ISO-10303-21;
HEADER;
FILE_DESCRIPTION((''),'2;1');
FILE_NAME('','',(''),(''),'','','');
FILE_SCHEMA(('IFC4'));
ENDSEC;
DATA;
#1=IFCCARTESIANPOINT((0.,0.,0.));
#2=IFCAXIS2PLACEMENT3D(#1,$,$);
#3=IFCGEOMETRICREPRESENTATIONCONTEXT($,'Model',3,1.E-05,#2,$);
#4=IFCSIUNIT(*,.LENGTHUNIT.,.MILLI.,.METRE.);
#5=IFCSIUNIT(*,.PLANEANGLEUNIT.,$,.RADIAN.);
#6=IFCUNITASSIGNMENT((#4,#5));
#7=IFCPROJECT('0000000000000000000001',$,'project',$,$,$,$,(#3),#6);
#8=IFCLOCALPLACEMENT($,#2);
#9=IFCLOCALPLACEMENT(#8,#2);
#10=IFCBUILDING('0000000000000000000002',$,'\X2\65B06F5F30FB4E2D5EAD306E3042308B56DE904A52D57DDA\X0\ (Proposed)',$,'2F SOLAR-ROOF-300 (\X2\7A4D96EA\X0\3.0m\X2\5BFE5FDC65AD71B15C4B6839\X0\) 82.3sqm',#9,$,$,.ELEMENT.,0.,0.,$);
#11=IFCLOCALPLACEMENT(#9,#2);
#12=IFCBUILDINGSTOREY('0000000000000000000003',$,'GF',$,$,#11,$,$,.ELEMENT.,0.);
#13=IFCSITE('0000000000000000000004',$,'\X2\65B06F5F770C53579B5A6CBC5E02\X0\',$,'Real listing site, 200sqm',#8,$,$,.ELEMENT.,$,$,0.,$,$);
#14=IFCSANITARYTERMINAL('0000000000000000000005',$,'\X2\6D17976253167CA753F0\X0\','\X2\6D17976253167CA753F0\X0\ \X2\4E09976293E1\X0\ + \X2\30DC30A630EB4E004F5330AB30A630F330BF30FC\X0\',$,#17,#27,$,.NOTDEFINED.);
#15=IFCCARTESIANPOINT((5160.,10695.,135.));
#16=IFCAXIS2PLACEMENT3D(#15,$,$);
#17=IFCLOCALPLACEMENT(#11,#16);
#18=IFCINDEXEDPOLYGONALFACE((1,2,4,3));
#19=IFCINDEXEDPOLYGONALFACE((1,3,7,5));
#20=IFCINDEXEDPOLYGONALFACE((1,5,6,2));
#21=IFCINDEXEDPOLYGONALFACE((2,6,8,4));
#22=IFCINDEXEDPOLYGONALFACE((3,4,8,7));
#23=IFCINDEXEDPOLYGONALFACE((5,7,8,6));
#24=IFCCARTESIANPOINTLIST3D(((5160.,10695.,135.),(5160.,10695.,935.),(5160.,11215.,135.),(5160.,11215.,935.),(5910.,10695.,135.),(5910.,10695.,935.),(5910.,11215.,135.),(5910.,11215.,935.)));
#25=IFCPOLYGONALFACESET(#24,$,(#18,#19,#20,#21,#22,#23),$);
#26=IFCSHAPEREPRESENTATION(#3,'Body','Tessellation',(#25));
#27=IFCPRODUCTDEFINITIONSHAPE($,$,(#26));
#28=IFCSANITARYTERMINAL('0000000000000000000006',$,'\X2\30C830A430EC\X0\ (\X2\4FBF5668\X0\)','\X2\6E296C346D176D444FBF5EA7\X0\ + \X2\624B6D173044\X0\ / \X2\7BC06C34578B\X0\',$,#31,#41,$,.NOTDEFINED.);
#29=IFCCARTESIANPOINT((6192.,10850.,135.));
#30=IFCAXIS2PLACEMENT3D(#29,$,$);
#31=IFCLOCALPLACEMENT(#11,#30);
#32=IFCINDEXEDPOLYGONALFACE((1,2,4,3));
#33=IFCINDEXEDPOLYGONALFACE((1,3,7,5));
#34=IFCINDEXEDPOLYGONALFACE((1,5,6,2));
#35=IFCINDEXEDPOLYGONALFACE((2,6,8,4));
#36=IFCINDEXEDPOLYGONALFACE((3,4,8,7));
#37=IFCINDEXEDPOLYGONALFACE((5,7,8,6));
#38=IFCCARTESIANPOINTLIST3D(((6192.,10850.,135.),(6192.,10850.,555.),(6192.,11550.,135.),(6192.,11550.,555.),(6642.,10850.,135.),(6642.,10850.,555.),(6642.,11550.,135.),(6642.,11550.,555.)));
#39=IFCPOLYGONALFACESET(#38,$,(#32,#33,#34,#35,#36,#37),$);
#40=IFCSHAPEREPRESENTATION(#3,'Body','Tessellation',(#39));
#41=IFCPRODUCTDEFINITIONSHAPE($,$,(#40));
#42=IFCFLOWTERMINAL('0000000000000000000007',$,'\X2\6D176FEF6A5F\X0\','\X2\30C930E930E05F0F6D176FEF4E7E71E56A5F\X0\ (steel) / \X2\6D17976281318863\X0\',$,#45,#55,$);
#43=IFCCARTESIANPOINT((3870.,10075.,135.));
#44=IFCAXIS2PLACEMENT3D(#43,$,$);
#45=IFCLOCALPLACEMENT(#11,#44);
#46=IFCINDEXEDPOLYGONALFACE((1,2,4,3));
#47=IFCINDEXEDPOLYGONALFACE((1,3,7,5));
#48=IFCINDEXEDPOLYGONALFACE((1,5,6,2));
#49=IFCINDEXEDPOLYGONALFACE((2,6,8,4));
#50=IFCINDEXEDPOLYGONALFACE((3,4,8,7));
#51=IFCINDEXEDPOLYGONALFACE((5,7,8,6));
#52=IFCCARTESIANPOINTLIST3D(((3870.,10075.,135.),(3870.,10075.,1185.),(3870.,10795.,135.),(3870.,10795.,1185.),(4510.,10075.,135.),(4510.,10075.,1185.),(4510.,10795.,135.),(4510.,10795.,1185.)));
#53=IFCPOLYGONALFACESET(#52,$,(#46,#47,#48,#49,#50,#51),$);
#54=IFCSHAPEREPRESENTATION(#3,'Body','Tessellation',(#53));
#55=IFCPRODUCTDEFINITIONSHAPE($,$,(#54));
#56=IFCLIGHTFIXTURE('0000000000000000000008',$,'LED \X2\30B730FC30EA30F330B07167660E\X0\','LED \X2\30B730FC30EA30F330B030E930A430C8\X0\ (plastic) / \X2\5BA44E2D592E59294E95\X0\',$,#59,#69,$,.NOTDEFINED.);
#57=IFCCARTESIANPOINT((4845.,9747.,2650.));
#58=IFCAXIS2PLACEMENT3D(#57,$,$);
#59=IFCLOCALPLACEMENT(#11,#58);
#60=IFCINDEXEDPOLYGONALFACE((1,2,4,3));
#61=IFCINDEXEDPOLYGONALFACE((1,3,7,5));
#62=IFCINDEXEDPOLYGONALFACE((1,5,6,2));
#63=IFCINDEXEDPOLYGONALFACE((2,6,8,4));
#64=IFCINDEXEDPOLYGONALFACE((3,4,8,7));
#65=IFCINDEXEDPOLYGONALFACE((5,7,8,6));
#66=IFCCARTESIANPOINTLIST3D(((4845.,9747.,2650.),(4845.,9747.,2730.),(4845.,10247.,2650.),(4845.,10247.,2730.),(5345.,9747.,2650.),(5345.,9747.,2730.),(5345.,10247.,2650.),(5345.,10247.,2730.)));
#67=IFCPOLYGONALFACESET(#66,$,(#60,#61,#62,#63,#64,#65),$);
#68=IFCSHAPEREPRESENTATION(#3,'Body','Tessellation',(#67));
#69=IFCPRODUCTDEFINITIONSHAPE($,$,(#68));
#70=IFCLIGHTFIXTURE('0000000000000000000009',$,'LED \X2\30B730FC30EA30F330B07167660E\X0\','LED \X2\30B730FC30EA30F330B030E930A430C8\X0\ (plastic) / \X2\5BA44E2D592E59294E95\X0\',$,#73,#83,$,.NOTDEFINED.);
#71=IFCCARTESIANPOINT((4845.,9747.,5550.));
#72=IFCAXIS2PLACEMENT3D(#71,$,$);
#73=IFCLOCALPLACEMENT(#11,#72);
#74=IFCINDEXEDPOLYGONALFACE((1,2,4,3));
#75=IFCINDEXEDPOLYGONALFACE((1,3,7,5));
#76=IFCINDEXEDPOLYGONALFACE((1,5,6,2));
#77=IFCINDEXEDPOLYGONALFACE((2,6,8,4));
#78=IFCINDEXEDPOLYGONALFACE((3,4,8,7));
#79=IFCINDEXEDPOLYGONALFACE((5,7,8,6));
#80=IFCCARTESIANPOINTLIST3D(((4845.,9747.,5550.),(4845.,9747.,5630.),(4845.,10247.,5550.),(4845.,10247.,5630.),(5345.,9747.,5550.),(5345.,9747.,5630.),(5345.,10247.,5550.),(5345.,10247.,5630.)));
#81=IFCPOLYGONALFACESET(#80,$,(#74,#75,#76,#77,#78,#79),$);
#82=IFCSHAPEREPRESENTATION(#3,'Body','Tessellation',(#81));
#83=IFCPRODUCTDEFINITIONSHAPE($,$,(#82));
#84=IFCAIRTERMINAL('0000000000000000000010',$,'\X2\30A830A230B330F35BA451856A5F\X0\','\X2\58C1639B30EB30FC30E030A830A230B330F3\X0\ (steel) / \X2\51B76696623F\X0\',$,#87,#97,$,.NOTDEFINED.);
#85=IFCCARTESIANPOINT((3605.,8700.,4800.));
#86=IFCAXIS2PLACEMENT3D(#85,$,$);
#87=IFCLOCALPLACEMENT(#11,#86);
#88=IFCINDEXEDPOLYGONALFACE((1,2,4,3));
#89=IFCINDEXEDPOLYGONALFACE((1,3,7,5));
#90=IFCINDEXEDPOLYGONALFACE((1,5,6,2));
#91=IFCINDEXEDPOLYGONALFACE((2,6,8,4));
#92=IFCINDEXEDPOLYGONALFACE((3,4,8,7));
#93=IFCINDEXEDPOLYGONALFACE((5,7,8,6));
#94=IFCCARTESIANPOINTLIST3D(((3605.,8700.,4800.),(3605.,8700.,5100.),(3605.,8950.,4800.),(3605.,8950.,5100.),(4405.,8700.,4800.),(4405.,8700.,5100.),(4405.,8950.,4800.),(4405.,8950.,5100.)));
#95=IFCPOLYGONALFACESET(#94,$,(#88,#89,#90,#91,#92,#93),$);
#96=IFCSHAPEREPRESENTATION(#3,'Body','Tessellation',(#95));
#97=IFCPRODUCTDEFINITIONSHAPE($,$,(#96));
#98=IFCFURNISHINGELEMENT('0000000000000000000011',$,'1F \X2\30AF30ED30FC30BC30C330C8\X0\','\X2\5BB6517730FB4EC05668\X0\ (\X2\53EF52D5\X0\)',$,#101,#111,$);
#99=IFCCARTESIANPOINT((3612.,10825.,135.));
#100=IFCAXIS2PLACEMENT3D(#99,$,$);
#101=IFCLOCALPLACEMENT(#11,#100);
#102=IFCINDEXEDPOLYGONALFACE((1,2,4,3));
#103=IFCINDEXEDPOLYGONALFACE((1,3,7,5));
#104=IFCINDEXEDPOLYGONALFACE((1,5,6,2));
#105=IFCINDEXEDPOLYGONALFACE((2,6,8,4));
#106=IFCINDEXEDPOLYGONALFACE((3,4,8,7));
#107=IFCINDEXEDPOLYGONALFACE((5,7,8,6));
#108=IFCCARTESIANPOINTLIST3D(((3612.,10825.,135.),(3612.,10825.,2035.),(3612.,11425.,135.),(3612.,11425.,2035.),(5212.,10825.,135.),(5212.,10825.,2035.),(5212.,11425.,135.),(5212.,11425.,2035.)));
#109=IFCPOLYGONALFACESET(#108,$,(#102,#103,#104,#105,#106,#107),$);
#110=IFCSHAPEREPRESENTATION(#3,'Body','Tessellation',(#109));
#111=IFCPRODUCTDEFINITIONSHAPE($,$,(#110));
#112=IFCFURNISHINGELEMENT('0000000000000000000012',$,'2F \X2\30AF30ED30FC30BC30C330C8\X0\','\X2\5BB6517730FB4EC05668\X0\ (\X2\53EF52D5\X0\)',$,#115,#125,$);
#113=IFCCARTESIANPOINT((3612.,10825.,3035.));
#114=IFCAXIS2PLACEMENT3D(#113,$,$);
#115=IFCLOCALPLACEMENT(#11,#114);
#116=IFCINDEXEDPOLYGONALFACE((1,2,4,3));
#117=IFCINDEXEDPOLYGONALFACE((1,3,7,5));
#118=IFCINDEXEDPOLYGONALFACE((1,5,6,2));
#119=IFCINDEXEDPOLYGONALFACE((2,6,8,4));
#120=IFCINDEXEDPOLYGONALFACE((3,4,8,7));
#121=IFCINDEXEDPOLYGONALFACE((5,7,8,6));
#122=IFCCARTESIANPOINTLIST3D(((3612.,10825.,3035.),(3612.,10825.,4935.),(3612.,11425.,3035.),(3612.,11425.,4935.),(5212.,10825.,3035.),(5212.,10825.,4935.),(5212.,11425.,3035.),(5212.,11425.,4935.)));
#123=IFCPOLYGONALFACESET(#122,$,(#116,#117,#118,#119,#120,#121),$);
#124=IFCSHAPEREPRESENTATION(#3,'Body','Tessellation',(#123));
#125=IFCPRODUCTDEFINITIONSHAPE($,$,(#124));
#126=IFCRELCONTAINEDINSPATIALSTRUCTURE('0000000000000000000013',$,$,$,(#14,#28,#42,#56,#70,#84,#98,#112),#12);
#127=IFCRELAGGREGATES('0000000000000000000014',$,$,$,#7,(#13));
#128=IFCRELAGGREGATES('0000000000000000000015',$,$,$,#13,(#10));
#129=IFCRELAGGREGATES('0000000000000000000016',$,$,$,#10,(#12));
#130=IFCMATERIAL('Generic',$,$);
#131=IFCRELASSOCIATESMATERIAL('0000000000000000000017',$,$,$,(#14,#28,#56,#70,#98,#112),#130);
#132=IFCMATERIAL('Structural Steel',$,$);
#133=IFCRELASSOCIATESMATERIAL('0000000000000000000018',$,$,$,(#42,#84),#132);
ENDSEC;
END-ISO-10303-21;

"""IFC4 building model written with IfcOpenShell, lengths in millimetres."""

from ifc_helpers import new_model, si_unit, frame, frame_2d, origin, place, context, project, spatial, rectangle, extrude, material, element, save


model = new_model("IFC4")

# Units and contexts
model_context = context("Model", 3, precision=1e-05, world=origin())
ifc_project = project(units=[si_unit("LENGTHUNIT", "METRE", prefix="MILLI"), si_unit("PLANEANGLEUNIT", "RADIAN")], contexts=[model_context])

# Site, building, storey
site_placement = place(None, origin())
site = spatial("IfcSite", under=ifc_project, at=site_placement, Name="新潟県南魚沼市", ObjectType="Real listing site, 200sqm", CompositionType="ELEMENT", RefElevation=0.0)
building_placement = place(site_placement, origin())
building = spatial("IfcBuilding", under=site, at=building_placement, Name="新潟・中庭のある回遊動線 (Proposed)", ObjectType="2F SOLAR-ROOF-300 (積雪3.0m対応断熱屋根) 82.3sqm", CompositionType="ELEMENT", ElevationOfRefHeight=0.0, ElevationOfTerrain=0.0)
storey_placement = place(building_placement, origin())
storey = spatial("IfcBuildingStorey", under=building, at=storey_placement, Name="GF", CompositionType="ELEMENT", Elevation=0.0)

# Sanitary terminals
ifc_material_1 = material(Name="Generic")
sanitary_terminal_1_placement = place(storey_placement, frame((5160.0, 10695.0, 135.0)))
element("IfcSanitaryTerminal", 1, at=sanitary_terminal_1_placement, inside=storey, material=ifc_material_1, Name="洗面化粧台", Description="洗面化粧台 三面鏡 + ボウル一体カウンター", PredefinedType="NOTDEFINED", context=model_context, shape_type="SweptSolid", body=[
    extrude(rectangle(XDim=750.0, YDim=520.0, at=frame_2d((375.0, 260.0))), frame((5160.0, 10695.0, 135.0)), (0.0, 0.0, 1.0), 800.0),
])
sanitary_terminal_2_placement = place(storey_placement, frame((6192.0, 10850.0, 135.0)))
element("IfcSanitaryTerminal", 2, at=sanitary_terminal_2_placement, inside=storey, material=ifc_material_1, Name="トイレ (便器)", Description="温水洗浄便座 + 手洗い / 節水型", PredefinedType="NOTDEFINED", context=model_context, shape_type="SweptSolid", body=[
    extrude(rectangle(XDim=450.0, YDim=700.0, at=frame_2d((225.0, 350.0))), frame((6192.0, 10850.0, 135.0)), (0.0, 0.0, 1.0), 420.0),
])

# Flow terminal
ifc_material_2 = material(Name="Structural Steel")
flow_terminal_placement = place(storey_placement, frame((3870.0, 10075.0, 135.0)))
element("IfcFlowTerminal", 3, at=flow_terminal_placement, inside=storey, material=ifc_material_2, Name="洗濯機", Description="ドラム式洗濯乾燥機 (steel) / 洗面脱衣", context=model_context, shape_type="SweptSolid", body=[
    extrude(rectangle(XDim=640.0, YDim=720.0, at=frame_2d((320.0, 360.0))), frame((3870.0, 10075.0, 135.0)), (0.0, 0.0, 1.0), 1050.0),
])

# Light fixtures
light_fixture_1_placement = place(storey_placement, frame((4845.0, 9747.0, 2650.0)))
element("IfcLightFixture", 4, at=light_fixture_1_placement, inside=storey, material=ifc_material_1, Name="LED シーリング照明", Description="LED シーリングライト (plastic) / 室中央天井", PredefinedType="NOTDEFINED", context=model_context, shape_type="SweptSolid", body=[
    extrude(rectangle(XDim=500.0, YDim=500.0, at=frame_2d((250.0, 250.0))), frame((4845.0, 9747.0, 2650.0)), (0.0, 0.0, 1.0), 80.0),
])
light_fixture_2_placement = place(storey_placement, frame((4845.0, 9747.0, 5550.0)))
element("IfcLightFixture", 5, at=light_fixture_2_placement, inside=storey, material=ifc_material_1, Name="LED シーリング照明", Description="LED シーリングライト (plastic) / 室中央天井", PredefinedType="NOTDEFINED", context=model_context, shape_type="SweptSolid", body=[
    extrude(rectangle(XDim=500.0, YDim=500.0, at=frame_2d((250.0, 250.0))), frame((4845.0, 9747.0, 5550.0)), (0.0, 0.0, 1.0), 80.0),
])

# Air terminal
air_terminal_placement = place(storey_placement, frame((3605.0, 8700.0, 4800.0)))
element("IfcAirTerminal", 6, at=air_terminal_placement, inside=storey, material=ifc_material_2, Name="エアコン室内機", Description="壁掛ルームエアコン (steel) / 冷暖房", PredefinedType="NOTDEFINED", context=model_context, shape_type="SweptSolid", body=[
    extrude(rectangle(XDim=800.0, YDim=250.0, at=frame_2d((400.0, 125.0))), frame((3605.0, 8700.0, 4800.0)), (0.0, 0.0, 1.0), 300.0),
])

# Furnishing elements
furnishing_1_placement = place(storey_placement, frame((3612.0, 10825.0, 135.0)))
element("IfcFurnishingElement", 7, at=furnishing_1_placement, inside=storey, material=ifc_material_1, Name="1F クローゼット", Description="家具・什器 (可動)", context=model_context, shape_type="SweptSolid", body=[
    extrude(rectangle(XDim=1600.0, YDim=600.0, at=frame_2d((800.0, 300.0))), frame((3612.0, 10825.0, 135.0)), (0.0, 0.0, 1.0), 1900.0),
])
furnishing_2_placement = place(storey_placement, frame((3612.0, 10825.0, 3035.0)))
element("IfcFurnishingElement", 8, at=furnishing_2_placement, inside=storey, material=ifc_material_1, Name="2F クローゼット", Description="家具・什器 (可動)", context=model_context, shape_type="SweptSolid", body=[
    extrude(rectangle(XDim=1600.0, YDim=600.0, at=frame_2d((800.0, 300.0))), frame((3612.0, 10825.0, 3035.0)), (0.0, 0.0, 1.0), 1900.0),
])

save(model, "model.ifc")
